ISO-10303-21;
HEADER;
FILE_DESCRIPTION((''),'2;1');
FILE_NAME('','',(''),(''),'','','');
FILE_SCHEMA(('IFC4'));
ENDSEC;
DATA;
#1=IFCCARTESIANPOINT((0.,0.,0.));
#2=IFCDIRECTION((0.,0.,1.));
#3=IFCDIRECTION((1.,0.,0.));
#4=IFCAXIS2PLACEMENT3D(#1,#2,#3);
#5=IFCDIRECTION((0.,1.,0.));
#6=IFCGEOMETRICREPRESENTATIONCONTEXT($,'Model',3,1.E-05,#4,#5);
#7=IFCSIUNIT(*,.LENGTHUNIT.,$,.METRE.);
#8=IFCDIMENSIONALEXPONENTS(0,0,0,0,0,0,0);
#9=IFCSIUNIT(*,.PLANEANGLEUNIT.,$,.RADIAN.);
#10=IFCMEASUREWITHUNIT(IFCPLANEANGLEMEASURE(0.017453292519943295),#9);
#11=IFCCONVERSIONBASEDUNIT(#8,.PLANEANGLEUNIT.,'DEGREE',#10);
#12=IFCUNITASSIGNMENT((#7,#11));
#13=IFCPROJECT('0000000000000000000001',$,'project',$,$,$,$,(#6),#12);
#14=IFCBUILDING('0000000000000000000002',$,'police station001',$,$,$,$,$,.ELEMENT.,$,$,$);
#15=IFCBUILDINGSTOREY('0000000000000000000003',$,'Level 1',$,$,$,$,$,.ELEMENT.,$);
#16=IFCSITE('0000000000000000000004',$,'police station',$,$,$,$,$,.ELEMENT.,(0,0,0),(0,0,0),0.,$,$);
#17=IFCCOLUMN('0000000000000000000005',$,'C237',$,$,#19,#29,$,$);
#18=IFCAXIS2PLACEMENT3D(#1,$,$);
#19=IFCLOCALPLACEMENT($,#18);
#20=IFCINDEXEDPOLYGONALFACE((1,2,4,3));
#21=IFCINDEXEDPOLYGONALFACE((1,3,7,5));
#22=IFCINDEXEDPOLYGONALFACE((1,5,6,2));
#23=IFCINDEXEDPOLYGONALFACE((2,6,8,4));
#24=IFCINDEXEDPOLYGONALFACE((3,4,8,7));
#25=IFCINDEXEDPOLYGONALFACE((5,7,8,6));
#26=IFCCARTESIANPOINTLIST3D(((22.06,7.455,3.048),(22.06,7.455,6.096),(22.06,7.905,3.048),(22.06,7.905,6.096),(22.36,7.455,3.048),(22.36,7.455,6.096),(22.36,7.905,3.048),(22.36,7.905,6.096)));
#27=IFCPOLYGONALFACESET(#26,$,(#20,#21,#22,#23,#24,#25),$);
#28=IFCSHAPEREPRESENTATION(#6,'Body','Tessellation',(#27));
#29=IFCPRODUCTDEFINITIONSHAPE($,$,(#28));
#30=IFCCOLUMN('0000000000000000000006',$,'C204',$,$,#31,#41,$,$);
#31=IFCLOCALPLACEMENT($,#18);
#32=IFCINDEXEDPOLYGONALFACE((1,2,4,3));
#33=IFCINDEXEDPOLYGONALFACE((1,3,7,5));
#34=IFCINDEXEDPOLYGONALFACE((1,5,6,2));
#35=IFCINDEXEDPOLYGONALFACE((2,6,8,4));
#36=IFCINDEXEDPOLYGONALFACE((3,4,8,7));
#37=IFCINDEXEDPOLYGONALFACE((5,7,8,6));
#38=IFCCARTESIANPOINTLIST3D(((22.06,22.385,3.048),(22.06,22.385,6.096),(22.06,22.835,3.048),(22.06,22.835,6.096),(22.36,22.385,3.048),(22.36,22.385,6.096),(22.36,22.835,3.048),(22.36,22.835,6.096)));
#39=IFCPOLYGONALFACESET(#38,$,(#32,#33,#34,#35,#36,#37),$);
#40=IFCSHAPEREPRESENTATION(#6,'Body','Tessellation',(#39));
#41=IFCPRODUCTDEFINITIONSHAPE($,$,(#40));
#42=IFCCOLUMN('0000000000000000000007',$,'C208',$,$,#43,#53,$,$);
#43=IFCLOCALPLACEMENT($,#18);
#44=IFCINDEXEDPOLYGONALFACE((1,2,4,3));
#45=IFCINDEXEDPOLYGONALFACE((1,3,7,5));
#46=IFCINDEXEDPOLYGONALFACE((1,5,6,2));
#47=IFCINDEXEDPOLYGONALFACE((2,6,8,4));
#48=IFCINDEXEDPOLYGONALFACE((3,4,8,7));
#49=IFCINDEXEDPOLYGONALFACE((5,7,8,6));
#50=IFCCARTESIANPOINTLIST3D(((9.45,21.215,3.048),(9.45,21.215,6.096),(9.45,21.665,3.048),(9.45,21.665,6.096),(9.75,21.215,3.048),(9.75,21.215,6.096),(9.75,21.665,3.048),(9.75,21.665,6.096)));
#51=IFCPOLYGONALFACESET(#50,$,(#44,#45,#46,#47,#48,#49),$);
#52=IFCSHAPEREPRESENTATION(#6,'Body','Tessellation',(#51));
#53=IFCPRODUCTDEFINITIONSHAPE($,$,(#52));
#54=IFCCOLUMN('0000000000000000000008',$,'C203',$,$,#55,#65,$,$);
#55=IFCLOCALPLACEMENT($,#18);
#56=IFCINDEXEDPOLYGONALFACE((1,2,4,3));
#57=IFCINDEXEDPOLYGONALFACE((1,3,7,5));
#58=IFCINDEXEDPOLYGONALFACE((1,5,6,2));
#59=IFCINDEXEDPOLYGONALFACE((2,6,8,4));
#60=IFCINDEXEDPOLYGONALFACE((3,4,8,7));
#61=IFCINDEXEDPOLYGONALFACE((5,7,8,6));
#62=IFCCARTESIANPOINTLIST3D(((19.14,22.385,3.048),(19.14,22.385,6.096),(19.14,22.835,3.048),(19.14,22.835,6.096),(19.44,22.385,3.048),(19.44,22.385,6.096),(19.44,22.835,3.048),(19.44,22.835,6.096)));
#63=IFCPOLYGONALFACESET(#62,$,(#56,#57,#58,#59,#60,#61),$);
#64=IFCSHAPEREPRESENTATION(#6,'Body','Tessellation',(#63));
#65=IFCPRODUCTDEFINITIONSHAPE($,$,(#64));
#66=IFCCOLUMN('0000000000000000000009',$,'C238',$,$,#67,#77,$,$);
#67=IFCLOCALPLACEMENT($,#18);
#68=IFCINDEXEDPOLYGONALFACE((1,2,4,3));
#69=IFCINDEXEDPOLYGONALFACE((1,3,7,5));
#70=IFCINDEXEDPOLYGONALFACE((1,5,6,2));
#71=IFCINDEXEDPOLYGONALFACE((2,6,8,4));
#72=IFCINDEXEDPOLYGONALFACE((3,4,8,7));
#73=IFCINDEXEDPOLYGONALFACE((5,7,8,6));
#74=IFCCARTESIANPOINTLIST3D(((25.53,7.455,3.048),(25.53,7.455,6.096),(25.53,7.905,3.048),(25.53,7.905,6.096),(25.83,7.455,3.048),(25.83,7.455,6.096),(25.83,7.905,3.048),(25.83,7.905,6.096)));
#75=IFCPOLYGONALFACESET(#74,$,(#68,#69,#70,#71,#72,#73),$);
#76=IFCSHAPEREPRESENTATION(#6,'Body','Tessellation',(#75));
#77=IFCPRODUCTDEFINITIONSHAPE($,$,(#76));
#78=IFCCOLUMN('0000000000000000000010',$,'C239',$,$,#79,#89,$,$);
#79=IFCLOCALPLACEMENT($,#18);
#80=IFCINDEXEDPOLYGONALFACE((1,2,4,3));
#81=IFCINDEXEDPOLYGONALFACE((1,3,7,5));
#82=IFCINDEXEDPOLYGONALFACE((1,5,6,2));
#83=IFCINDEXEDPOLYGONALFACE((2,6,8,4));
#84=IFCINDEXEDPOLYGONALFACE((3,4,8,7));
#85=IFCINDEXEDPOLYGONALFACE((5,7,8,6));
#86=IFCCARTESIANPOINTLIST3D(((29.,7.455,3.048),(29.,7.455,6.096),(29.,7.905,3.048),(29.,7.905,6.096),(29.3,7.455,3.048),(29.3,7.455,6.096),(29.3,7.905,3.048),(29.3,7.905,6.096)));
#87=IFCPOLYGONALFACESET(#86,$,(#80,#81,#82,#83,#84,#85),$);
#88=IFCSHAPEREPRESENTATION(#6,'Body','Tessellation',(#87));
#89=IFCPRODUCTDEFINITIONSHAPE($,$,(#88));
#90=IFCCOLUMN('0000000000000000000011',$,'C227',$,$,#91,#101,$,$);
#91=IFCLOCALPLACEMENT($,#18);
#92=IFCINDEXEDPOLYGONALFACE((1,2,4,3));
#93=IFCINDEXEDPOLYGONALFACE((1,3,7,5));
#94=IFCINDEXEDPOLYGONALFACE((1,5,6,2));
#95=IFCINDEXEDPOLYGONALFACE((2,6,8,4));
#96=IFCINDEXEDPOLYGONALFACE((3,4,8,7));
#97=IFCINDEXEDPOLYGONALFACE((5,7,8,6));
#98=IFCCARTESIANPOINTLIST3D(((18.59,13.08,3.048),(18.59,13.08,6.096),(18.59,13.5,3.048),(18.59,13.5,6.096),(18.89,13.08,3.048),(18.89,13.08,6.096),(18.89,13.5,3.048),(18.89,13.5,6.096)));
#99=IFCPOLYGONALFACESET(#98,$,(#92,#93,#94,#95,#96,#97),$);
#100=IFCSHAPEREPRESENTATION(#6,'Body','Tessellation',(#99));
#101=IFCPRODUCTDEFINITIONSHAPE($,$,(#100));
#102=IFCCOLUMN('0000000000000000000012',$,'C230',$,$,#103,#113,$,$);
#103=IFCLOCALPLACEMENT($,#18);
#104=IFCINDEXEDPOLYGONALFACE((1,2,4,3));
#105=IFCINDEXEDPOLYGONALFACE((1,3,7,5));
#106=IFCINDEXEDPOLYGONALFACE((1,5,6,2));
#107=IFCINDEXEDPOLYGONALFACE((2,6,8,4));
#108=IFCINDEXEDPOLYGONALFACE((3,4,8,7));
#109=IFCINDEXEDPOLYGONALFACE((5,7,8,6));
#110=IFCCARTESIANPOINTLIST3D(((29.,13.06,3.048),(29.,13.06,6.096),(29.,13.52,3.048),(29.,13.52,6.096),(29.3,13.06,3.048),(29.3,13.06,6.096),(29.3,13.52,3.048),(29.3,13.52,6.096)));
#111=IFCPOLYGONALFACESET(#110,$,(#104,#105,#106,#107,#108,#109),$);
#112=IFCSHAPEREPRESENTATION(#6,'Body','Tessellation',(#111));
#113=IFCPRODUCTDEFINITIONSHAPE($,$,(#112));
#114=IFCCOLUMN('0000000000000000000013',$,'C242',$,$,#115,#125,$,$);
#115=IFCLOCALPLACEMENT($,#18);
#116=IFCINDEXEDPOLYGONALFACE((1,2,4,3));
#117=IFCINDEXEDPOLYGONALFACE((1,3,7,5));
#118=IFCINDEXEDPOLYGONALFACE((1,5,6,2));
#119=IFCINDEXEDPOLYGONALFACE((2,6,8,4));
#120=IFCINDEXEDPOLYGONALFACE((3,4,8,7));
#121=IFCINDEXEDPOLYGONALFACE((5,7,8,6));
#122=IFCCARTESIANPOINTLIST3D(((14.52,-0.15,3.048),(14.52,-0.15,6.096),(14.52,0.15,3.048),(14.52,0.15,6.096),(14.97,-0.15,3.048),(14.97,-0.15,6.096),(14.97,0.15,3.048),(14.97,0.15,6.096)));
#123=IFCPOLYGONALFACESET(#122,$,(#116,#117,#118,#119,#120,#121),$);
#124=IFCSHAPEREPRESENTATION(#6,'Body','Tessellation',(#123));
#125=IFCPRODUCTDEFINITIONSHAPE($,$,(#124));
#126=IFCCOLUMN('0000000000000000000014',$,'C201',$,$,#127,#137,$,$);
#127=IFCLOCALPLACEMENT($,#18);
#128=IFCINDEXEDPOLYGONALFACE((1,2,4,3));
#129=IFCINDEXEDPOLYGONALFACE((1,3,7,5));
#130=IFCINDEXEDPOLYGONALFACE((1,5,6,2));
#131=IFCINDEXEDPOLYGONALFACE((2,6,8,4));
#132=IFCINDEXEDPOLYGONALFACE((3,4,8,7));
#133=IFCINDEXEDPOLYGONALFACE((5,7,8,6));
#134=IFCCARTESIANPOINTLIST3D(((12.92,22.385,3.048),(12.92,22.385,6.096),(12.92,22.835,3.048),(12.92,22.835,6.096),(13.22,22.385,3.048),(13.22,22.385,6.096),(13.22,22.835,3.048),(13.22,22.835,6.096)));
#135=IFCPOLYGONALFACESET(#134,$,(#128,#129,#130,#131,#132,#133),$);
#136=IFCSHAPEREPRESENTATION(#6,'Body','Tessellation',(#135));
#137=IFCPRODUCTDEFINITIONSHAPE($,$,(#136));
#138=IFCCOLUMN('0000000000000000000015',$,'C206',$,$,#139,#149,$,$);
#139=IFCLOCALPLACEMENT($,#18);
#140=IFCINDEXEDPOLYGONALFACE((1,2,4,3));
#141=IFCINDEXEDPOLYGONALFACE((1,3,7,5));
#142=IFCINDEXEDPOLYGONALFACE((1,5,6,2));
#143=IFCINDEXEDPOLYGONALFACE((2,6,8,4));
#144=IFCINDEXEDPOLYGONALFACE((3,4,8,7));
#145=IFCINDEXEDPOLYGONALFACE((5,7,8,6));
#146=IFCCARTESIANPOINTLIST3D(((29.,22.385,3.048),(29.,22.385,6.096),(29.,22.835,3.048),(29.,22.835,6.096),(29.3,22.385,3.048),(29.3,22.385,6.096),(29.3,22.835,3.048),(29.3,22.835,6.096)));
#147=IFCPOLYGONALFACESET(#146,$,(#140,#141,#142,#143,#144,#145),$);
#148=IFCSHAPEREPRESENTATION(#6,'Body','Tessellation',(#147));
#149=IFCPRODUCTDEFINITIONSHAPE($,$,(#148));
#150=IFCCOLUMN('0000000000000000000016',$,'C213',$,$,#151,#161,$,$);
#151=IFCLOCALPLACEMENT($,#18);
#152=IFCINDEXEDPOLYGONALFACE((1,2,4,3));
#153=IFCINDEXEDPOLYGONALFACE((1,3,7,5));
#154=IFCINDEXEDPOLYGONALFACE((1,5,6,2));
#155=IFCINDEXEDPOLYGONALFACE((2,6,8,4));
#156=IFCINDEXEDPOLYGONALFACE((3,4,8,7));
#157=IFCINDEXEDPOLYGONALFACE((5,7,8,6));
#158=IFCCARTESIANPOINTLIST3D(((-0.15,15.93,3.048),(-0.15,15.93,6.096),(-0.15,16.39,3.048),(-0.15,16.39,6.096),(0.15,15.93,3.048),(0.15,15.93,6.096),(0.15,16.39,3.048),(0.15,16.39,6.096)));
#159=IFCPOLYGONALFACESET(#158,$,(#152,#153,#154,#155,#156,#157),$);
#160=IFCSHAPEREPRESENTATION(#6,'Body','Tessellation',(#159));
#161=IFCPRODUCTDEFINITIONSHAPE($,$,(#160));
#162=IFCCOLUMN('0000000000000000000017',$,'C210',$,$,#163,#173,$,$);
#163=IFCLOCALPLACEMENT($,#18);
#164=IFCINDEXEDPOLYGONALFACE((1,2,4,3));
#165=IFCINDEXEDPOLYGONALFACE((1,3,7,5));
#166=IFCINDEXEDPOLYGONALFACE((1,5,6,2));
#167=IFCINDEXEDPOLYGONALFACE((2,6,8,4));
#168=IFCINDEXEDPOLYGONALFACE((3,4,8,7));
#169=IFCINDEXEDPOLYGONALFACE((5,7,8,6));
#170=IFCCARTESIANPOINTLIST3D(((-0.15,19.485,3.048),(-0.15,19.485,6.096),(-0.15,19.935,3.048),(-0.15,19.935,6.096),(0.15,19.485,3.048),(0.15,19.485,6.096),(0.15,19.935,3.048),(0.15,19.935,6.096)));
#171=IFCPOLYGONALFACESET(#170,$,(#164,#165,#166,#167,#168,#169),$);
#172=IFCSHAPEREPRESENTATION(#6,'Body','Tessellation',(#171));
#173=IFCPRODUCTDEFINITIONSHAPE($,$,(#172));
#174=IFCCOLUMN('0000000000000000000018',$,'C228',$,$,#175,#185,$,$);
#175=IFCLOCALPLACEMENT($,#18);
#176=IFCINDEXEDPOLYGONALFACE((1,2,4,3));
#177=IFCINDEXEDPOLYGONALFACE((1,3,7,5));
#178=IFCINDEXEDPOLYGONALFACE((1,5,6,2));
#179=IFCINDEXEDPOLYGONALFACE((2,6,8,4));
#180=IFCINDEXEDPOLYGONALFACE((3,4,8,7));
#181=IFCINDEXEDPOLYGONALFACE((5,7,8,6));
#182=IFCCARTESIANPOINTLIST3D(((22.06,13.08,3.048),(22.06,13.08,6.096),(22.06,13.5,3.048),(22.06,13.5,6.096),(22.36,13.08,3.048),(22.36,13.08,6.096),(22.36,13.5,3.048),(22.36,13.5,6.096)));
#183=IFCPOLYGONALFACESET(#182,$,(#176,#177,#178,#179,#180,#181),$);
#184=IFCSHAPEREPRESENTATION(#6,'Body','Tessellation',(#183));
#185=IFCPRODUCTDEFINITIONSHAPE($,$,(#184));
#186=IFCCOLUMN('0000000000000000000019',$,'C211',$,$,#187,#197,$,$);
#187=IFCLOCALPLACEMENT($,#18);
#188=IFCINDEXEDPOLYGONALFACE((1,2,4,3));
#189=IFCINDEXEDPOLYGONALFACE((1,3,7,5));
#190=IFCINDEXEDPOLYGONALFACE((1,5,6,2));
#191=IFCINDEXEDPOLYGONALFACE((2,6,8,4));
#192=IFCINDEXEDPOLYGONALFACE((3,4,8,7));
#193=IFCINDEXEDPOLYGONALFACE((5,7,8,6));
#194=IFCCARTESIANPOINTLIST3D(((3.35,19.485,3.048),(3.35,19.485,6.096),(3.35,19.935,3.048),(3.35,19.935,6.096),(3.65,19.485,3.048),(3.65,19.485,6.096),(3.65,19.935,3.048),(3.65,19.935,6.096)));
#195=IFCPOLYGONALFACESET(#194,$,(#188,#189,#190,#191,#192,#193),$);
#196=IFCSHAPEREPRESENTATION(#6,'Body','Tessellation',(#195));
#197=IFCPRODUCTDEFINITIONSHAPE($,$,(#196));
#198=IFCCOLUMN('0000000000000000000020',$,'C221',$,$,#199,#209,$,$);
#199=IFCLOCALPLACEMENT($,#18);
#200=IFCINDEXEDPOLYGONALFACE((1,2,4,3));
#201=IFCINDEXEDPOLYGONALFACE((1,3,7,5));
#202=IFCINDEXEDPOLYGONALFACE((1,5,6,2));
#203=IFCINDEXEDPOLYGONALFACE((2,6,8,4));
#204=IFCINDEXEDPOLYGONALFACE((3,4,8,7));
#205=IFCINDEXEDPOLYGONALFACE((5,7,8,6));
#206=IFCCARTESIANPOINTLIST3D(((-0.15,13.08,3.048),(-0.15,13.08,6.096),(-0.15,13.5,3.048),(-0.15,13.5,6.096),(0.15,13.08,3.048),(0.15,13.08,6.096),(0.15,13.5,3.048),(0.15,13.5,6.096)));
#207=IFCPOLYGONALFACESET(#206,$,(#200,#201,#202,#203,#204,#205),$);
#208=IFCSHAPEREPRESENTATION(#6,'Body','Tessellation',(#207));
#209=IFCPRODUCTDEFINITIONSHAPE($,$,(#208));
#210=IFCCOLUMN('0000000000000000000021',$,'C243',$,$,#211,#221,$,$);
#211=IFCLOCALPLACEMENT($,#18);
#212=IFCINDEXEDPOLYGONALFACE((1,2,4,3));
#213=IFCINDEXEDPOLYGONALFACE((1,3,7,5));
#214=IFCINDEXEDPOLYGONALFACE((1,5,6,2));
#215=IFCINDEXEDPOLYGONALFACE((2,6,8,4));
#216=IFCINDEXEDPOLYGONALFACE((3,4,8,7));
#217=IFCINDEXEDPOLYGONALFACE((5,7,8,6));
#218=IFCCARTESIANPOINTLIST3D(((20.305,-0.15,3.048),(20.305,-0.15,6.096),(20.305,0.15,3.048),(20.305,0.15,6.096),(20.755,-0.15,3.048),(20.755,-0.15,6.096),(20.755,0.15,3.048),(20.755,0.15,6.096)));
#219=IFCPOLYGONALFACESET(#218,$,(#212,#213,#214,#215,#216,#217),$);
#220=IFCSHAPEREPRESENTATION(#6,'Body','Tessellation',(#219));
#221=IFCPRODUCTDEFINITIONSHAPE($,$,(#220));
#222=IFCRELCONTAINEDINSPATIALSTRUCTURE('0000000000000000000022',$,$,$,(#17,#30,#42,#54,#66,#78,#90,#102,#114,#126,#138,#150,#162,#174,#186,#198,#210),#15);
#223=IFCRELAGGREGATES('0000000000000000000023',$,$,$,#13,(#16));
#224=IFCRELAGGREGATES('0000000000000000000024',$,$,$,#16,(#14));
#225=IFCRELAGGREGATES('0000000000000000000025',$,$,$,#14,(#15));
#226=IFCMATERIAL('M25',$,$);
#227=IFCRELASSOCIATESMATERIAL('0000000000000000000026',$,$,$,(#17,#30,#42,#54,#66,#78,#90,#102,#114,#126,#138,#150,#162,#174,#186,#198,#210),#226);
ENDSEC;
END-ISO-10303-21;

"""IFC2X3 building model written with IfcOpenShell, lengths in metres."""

from ifc_helpers import new_model, entity, si_unit, converted_unit, direction, frame, frame_2d, origin_with_axes, place, context, project, spatial, rectangle, extrude, material, element, save


model = new_model("IFC2X3")

# Units and contexts
model_context = context("Model", 3, precision=1e-05, world=origin_with_axes(), true_north=direction((0.0, 1.0, 0.0)))
ifc_project = project(units=[si_unit("LENGTHUNIT", "METRE"), converted_unit("PLANEANGLEUNIT", "DEGREE", entity("IfcPlaneAngleMeasure", 0.017453292519943295), si_unit("PLANEANGLEUNIT", "RADIAN"), dimensions=[0, 0, 0, 0, 0, 0, 0])], contexts=[model_context])

# Site, building, storey
site = spatial("IfcSite", under=ifc_project, Name="police station", CompositionType="ELEMENT", RefLatitude=(0, 0, 0), RefLongitude=(0, 0, 0), RefElevation=0.0)
building = spatial("IfcBuilding", under=site, Name="police station001", CompositionType="ELEMENT")
storey = spatial("IfcBuildingStorey", under=building, Name="Level 1", CompositionType="ELEMENT")

# Columns
ifc_material = material(Name="M25")
placement = place(None, origin_with_axes())
element("IfcColumn", 1, at=placement, inside=storey, material=ifc_material, Name="C237", context=model_context, shape_type="SweptSolid", body=[
    extrude(rectangle(XDim=0.3, YDim=0.45, at=frame_2d((0.0, 0.0), x_axis=(1.0, 0.0, 0.0))), frame((22.21, 7.68, 3.048), z_axis=(0.0, 0.0, 1.0), x_axis=(1.0, 0.0, 0.0)), (0.0, 0.0, 1.0), 3.048),
])
element("IfcColumn", 2, at=placement, inside=storey, material=ifc_material, Name="C204", context=model_context, shape_type="SweptSolid", body=[
    extrude(rectangle(XDim=0.3, YDim=0.45, at=frame_2d((0.0, 0.0), x_axis=(1.0, 0.0, 0.0))), frame((22.21, 22.61, 3.048), z_axis=(0.0, 0.0, 1.0), x_axis=(1.0, 0.0, 0.0)), (0.0, 0.0, 1.0), 3.048),
])
element("IfcColumn", 3, at=placement, inside=storey, material=ifc_material, Name="C208", context=model_context, shape_type="SweptSolid", body=[
    extrude(rectangle(XDim=0.3, YDim=0.45, at=frame_2d((0.0, 0.0), x_axis=(1.0, 0.0, 0.0))), frame((9.6, 21.44, 3.048), z_axis=(0.0, 0.0, 1.0), x_axis=(1.0, 0.0, 0.0)), (0.0, 0.0, 1.0), 3.048),
])
element("IfcColumn", 4, at=placement, inside=storey, material=ifc_material, Name="C203", context=model_context, shape_type="SweptSolid", body=[
    extrude(rectangle(XDim=0.3, YDim=0.45, at=frame_2d((0.0, 0.0), x_axis=(1.0, 0.0, 0.0))), frame((19.29, 22.61, 3.048), z_axis=(0.0, 0.0, 1.0), x_axis=(1.0, 0.0, 0.0)), (0.0, 0.0, 1.0), 3.048),
])
element("IfcColumn", 5, at=placement, inside=storey, material=ifc_material, Name="C238", context=model_context, shape_type="SweptSolid", body=[
    extrude(rectangle(XDim=0.3, YDim=0.45, at=frame_2d((0.0, 0.0), x_axis=(1.0, 0.0, 0.0))), frame((25.68, 7.68, 3.048), z_axis=(0.0, 0.0, 1.0), x_axis=(1.0, 0.0, 0.0)), (0.0, 0.0, 1.0), 3.048),
])
element("IfcColumn", 6, at=placement, inside=storey, material=ifc_material, Name="C239", context=model_context, shape_type="SweptSolid", body=[
    extrude(rectangle(XDim=0.3, YDim=0.45, at=frame_2d((0.0, 0.0), x_axis=(1.0, 0.0, 0.0))), frame((29.15, 7.68, 3.048), z_axis=(0.0, 0.0, 1.0), x_axis=(1.0, 0.0, 0.0)), (0.0, 0.0, 1.0), 3.048),
])
element("IfcColumn", 7, at=placement, inside=storey, material=ifc_material, Name="C227", context=model_context, shape_type="SweptSolid", body=[
    extrude(rectangle(XDim=0.3, YDim=0.42, at=frame_2d((0.0, 0.0), x_axis=(1.0, 0.0, 0.0))), frame((18.74, 13.29, 3.048), z_axis=(0.0, 0.0, 1.0), x_axis=(1.0, 0.0, 0.0)), (0.0, 0.0, 1.0), 3.048),
])
element("IfcColumn", 8, at=placement, inside=storey, material=ifc_material, Name="C230", context=model_context, shape_type="SweptSolid", body=[
    extrude(rectangle(XDim=0.3, YDim=0.46, at=frame_2d((0.0, 0.0), x_axis=(1.0, 0.0, 0.0))), frame((29.15, 13.29, 3.048), z_axis=(0.0, 0.0, 1.0), x_axis=(1.0, 0.0, 0.0)), (0.0, 0.0, 1.0), 3.048),
])
element("IfcColumn", 9, at=placement, inside=storey, material=ifc_material, Name="C242", context=model_context, shape_type="SweptSolid", body=[
    extrude(rectangle(XDim=0.45, YDim=0.3, at=frame_2d((0.0, 0.0), x_axis=(1.0, 0.0, 0.0))), frame((14.745, 0.0, 3.048), z_axis=(0.0, 0.0, 1.0), x_axis=(1.0, 0.0, 0.0)), (0.0, 0.0, 1.0), 3.048),
])
element("IfcColumn", 10, at=placement, inside=storey, material=ifc_material, Name="C201", context=model_context, shape_type="SweptSolid", body=[
    extrude(rectangle(XDim=0.3, YDim=0.45, at=frame_2d((0.0, 0.0), x_axis=(1.0, 0.0, 0.0))), frame((13.07, 22.61, 3.048), z_axis=(0.0, 0.0, 1.0), x_axis=(1.0, 0.0, 0.0)), (0.0, 0.0, 1.0), 3.048),
])
element("IfcColumn", 11, at=placement, inside=storey, material=ifc_material, Name="C206", context=model_context, shape_type="SweptSolid", body=[
    extrude(rectangle(XDim=0.3, YDim=0.45, at=frame_2d((0.0, 0.0), x_axis=(1.0, 0.0, 0.0))), frame((29.15, 22.61, 3.048), z_axis=(0.0, 0.0, 1.0), x_axis=(1.0, 0.0, 0.0)), (0.0, 0.0, 1.0), 3.048),
])
element("IfcColumn", 12, at=placement, inside=storey, material=ifc_material, Name="C213", context=model_context, shape_type="SweptSolid", body=[
    extrude(rectangle(XDim=0.3, YDim=0.46, at=frame_2d((0.0, 0.0), x_axis=(1.0, 0.0, 0.0))), frame((0.0, 16.16, 3.048), z_axis=(0.0, 0.0, 1.0), x_axis=(1.0, 0.0, 0.0)), (0.0, 0.0, 1.0), 3.048),
])
element("IfcColumn", 13, at=placement, inside=storey, material=ifc_material, Name="C210", context=model_context, shape_type="SweptSolid", body=[
    extrude(rectangle(XDim=0.3, YDim=0.45, at=frame_2d((0.0, 0.0), x_axis=(1.0, 0.0, 0.0))), frame((0.0, 19.71, 3.048), z_axis=(0.0, 0.0, 1.0), x_axis=(1.0, 0.0, 0.0)), (0.0, 0.0, 1.0), 3.048),
])
element("IfcColumn", 14, at=placement, inside=storey, material=ifc_material, Name="C228", context=model_context, shape_type="SweptSolid", body=[
    extrude(rectangle(XDim=0.3, YDim=0.42, at=frame_2d((0.0, 0.0), x_axis=(1.0, 0.0, 0.0))), frame((22.21, 13.29, 3.048), z_axis=(0.0, 0.0, 1.0), x_axis=(1.0, 0.0, 0.0)), (0.0, 0.0, 1.0), 3.048),
])
element("IfcColumn", 15, at=placement, inside=storey, material=ifc_material, Name="C211", context=model_context, shape_type="SweptSolid", body=[
    extrude(rectangle(XDim=0.3, YDim=0.45, at=frame_2d((0.0, 0.0), x_axis=(1.0, 0.0, 0.0))), frame((3.5, 19.71, 3.048), z_axis=(0.0, 0.0, 1.0), x_axis=(1.0, 0.0, 0.0)), (0.0, 0.0, 1.0), 3.048),
])
element("IfcColumn", 16, at=placement, inside=storey, material=ifc_material, Name="C221", context=model_context, shape_type="SweptSolid", body=[
    extrude(rectangle(XDim=0.3, YDim=0.42, at=frame_2d((0.0, 0.0), x_axis=(1.0, 0.0, 0.0))), frame((0.0, 13.29, 3.048), z_axis=(0.0, 0.0, 1.0), x_axis=(1.0, 0.0, 0.0)), (0.0, 0.0, 1.0), 3.048),
])
element("IfcColumn", 17, at=placement, inside=storey, material=ifc_material, Name="C243", context=model_context, shape_type="SweptSolid", body=[
    extrude(rectangle(XDim=0.45, YDim=0.3, at=frame_2d((0.0, 0.0), x_axis=(1.0, 0.0, 0.0))), frame((20.53, 0.0, 3.048), z_axis=(0.0, 0.0, 1.0), x_axis=(1.0, 0.0, 0.0)), (0.0, 0.0, 1.0), 3.048),
])

save(model, "model.ifc")
